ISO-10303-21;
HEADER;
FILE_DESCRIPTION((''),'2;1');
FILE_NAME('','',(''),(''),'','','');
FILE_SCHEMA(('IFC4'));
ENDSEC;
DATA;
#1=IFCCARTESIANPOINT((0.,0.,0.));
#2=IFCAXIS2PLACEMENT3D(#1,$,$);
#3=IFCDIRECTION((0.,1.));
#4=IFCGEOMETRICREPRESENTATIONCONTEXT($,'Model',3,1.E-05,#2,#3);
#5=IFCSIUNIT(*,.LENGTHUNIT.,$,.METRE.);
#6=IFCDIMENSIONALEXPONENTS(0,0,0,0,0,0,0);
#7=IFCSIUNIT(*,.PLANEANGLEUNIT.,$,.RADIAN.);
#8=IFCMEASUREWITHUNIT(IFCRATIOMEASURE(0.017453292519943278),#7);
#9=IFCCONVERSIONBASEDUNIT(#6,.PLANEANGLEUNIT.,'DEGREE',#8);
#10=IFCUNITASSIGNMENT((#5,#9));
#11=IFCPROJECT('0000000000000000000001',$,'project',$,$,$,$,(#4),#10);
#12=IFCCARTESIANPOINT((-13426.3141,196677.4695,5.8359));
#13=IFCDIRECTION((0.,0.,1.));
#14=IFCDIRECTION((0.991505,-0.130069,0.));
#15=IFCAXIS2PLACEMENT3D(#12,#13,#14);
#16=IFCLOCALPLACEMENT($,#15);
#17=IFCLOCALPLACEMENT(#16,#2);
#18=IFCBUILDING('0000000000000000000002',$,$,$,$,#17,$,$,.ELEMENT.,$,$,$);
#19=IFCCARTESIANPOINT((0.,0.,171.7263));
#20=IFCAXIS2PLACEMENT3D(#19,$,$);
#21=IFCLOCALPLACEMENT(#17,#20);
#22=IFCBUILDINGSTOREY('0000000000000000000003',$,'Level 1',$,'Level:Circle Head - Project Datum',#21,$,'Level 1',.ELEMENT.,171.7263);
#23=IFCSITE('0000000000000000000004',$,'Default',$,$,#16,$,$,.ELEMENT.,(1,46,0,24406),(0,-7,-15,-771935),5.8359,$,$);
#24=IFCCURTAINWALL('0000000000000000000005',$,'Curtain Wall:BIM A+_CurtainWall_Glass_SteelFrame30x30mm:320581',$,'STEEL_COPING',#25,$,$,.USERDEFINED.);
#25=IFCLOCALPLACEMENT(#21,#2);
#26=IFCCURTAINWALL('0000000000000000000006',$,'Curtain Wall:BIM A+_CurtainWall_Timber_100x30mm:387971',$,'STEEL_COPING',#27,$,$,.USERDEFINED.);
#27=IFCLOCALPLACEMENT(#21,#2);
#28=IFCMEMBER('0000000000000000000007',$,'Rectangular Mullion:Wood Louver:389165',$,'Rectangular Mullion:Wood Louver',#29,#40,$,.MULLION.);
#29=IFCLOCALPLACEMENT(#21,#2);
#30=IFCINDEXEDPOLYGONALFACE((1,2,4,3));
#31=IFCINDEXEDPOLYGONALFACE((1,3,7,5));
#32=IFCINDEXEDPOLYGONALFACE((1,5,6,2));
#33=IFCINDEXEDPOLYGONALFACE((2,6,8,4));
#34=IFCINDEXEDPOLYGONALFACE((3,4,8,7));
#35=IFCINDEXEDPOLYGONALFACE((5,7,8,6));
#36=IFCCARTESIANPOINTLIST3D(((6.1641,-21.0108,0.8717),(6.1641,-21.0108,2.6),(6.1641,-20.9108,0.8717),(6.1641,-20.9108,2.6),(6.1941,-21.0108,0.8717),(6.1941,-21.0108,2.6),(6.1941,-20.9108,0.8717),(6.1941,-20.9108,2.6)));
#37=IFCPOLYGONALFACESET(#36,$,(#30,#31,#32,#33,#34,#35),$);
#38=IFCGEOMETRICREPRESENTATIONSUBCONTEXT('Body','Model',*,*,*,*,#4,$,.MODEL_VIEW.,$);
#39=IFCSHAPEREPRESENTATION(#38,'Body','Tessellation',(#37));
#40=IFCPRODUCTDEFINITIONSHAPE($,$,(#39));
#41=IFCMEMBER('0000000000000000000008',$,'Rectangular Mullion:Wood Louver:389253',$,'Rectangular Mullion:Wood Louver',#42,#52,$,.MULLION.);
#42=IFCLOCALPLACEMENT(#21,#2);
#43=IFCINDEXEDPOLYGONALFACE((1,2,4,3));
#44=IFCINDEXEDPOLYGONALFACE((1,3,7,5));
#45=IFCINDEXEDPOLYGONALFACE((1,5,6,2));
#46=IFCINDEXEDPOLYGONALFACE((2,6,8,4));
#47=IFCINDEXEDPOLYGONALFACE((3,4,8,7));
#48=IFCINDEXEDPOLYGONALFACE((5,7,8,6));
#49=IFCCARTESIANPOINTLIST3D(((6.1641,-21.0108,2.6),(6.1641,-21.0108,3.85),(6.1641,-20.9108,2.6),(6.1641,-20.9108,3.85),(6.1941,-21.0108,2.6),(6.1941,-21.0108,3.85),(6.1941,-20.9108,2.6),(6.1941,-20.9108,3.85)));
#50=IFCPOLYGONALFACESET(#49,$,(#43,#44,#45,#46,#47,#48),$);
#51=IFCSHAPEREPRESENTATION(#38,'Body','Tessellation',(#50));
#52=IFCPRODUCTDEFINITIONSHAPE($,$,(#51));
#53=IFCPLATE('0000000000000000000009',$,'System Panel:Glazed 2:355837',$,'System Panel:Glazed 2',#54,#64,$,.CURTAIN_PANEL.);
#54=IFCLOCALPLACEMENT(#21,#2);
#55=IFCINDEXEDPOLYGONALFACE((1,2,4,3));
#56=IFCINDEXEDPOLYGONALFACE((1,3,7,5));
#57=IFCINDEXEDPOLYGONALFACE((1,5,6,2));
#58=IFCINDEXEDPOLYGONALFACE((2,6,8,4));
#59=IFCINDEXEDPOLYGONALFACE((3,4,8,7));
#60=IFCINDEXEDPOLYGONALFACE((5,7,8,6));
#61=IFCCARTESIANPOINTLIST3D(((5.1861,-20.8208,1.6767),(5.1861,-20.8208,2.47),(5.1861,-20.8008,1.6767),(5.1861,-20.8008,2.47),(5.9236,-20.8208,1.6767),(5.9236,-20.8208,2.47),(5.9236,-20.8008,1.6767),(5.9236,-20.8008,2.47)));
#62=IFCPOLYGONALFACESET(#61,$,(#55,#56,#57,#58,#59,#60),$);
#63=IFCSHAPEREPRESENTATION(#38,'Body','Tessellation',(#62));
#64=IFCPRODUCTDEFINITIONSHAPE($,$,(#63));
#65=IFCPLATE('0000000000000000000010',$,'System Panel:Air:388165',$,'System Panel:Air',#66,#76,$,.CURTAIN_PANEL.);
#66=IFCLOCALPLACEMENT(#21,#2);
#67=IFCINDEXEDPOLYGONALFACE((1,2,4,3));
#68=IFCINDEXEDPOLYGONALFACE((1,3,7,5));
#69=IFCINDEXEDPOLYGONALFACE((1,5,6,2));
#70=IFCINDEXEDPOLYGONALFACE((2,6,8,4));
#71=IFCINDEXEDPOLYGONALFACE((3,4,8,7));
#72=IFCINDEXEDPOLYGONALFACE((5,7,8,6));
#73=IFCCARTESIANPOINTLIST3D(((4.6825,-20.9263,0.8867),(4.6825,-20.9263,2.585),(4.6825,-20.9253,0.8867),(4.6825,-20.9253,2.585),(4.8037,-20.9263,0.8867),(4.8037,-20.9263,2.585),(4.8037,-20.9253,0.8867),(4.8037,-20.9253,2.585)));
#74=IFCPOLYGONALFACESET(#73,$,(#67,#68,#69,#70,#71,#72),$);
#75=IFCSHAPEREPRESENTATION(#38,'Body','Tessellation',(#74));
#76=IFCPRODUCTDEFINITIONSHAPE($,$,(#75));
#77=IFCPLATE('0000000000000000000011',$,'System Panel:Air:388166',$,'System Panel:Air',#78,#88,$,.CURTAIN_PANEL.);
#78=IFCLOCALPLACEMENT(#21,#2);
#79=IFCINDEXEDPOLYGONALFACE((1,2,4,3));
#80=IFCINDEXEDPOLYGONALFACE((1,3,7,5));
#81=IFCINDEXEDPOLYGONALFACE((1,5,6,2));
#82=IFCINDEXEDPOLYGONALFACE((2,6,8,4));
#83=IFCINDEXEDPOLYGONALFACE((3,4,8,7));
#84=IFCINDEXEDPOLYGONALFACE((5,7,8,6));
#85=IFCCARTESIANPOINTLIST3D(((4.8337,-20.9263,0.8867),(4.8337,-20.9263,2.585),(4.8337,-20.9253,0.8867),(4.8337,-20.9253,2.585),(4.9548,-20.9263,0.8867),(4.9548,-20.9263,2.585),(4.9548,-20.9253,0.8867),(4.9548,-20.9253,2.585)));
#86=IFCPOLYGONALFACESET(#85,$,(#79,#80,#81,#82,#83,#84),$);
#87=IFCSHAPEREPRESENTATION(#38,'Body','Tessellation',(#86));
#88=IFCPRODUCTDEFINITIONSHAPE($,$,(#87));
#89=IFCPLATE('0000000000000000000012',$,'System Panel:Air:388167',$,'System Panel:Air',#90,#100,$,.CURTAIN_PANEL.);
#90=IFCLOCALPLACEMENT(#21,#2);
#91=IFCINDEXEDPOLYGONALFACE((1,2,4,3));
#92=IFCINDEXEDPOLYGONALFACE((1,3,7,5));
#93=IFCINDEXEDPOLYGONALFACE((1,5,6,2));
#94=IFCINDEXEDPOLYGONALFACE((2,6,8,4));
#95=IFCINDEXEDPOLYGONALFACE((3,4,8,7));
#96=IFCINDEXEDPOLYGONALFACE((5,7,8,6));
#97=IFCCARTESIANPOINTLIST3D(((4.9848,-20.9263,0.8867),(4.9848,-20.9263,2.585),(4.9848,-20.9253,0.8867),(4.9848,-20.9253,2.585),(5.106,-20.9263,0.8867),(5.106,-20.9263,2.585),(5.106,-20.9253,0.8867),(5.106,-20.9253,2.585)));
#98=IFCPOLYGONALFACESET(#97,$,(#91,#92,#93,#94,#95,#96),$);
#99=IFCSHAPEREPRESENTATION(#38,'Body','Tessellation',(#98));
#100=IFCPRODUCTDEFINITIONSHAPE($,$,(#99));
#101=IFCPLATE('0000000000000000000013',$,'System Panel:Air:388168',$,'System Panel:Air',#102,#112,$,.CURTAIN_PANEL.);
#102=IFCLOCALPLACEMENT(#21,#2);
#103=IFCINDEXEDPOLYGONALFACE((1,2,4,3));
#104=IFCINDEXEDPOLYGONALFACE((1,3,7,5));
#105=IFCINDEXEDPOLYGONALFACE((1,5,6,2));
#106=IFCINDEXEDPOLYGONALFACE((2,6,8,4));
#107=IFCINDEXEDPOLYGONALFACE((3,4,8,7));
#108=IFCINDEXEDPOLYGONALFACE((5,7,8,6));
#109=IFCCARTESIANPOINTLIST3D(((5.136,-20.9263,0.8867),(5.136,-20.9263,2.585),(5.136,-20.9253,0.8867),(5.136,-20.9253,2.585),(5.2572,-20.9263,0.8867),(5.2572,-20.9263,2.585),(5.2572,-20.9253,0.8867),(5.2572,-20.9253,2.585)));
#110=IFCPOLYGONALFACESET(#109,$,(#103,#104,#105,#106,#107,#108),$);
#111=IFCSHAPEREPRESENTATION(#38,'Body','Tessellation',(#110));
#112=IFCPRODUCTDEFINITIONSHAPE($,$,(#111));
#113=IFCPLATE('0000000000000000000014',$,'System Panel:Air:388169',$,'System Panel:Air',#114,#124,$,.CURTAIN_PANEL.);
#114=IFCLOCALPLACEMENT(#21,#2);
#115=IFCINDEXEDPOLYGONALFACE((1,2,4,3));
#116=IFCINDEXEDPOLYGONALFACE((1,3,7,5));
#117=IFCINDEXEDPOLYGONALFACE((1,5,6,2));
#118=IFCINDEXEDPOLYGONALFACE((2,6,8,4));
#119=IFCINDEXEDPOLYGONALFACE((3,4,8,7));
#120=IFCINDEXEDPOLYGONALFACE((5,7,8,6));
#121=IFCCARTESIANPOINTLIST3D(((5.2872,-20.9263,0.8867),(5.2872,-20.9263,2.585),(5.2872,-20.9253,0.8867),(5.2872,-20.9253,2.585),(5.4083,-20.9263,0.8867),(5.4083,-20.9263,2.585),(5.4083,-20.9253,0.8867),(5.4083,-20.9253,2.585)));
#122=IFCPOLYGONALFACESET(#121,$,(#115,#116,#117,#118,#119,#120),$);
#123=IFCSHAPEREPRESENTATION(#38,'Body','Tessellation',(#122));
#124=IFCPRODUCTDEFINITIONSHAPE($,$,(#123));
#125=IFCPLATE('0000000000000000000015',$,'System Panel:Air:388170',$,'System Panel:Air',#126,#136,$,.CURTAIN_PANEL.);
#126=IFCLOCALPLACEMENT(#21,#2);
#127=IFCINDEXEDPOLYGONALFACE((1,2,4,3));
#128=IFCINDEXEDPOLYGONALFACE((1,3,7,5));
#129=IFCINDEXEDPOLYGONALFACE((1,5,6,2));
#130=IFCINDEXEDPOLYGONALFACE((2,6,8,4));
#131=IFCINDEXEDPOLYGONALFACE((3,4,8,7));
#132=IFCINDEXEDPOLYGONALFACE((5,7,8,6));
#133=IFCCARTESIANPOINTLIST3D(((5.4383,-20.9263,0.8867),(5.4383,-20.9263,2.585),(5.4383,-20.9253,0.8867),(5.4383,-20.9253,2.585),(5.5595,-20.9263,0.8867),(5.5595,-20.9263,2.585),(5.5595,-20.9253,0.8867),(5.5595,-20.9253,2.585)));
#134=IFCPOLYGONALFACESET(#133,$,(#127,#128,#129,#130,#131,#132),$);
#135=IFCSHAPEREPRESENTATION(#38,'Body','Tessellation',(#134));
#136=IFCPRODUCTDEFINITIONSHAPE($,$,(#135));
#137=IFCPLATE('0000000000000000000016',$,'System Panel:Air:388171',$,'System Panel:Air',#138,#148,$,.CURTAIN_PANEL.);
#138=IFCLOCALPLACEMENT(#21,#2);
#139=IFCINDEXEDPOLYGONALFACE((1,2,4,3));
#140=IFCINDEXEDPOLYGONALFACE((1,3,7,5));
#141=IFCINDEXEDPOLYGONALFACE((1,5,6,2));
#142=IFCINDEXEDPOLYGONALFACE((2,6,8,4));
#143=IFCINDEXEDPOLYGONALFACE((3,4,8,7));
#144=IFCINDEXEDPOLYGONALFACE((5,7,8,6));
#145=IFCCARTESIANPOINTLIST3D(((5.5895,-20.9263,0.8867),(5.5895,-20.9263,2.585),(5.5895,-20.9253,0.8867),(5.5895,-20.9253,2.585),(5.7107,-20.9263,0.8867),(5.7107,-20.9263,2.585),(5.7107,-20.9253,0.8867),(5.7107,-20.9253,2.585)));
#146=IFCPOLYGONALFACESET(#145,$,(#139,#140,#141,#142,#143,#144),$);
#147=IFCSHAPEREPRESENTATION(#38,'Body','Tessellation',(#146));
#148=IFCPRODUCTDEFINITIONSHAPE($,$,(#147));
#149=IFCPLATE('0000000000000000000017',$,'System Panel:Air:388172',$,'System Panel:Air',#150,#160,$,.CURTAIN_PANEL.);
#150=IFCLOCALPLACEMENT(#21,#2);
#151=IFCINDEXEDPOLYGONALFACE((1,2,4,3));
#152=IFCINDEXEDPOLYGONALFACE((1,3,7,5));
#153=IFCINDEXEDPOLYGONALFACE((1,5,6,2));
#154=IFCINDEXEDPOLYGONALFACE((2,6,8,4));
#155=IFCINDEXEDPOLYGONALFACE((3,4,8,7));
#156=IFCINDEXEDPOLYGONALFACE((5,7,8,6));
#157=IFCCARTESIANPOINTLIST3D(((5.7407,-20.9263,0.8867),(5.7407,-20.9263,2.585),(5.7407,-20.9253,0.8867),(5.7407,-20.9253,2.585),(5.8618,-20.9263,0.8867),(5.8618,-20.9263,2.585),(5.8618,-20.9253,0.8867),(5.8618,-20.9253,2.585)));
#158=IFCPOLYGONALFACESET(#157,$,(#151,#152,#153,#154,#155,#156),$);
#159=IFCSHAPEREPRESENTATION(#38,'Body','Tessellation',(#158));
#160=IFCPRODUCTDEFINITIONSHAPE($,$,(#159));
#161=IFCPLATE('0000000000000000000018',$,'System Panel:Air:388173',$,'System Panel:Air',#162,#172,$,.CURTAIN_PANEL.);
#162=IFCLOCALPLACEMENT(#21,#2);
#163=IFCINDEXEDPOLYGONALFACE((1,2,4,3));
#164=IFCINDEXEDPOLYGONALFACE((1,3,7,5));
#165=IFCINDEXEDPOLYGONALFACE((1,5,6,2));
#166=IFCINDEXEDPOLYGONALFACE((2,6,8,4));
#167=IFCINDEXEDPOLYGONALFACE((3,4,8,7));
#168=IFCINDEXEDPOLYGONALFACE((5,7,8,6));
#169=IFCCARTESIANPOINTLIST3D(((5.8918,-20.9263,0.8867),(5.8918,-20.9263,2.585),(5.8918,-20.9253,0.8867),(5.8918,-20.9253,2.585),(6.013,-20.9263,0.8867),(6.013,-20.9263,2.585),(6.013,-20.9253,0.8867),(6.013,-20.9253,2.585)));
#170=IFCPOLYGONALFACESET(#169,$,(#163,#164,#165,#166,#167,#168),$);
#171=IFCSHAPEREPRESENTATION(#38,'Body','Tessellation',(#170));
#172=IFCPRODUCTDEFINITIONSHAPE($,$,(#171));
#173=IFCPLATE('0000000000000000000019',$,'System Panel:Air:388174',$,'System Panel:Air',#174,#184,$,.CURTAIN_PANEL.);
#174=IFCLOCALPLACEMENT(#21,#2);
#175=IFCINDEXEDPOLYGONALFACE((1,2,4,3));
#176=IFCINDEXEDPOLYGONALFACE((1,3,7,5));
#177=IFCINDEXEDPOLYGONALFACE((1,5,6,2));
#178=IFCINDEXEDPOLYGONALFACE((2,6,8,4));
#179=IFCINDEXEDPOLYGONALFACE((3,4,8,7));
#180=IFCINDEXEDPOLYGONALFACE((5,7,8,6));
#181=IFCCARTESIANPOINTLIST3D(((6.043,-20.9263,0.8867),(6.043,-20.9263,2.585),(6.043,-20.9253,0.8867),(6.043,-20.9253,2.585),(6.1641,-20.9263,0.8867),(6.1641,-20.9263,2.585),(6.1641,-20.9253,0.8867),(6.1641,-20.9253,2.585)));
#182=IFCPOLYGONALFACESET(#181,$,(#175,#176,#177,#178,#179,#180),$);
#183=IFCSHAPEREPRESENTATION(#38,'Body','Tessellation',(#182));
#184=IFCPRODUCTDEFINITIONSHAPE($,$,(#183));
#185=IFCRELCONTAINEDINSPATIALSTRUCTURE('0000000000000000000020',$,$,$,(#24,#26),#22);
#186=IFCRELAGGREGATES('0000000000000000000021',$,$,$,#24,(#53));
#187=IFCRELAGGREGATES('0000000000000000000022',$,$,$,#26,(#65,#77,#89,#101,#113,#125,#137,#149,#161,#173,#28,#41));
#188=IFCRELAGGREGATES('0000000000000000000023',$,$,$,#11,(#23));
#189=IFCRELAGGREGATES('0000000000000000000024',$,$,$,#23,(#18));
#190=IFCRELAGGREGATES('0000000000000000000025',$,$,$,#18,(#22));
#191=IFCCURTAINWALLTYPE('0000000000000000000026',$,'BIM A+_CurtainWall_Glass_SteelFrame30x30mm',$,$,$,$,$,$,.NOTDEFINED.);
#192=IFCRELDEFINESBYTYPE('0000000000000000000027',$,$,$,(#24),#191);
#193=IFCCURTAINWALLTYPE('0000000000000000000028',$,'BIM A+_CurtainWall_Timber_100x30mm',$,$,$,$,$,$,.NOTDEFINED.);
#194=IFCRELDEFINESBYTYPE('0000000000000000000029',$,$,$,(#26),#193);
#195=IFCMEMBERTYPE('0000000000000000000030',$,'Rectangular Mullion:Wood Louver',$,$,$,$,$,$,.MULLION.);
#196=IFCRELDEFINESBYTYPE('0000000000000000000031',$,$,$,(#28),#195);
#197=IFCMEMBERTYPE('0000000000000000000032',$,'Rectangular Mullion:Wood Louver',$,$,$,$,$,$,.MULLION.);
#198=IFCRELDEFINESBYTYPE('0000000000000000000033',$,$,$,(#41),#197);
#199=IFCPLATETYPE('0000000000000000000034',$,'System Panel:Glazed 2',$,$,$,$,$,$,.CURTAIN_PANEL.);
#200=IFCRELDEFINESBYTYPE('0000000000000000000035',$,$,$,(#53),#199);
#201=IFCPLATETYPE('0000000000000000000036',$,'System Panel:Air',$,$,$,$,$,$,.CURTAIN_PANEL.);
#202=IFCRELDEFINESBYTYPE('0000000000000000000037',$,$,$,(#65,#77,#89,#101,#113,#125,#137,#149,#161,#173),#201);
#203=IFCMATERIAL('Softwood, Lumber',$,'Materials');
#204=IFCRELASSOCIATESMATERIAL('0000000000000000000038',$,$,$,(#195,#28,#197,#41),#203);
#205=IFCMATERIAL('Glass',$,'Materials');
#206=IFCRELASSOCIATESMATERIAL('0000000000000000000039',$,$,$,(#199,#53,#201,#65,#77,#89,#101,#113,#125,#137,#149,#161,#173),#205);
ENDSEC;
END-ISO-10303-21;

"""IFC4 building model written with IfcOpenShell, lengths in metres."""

from ifc_helpers import new_model, entity, si_unit, converted_unit, direction, frame, origin, place, context, subcontext, project, spatial, indexed_curve, outline, extrude, source, transform, mapped, material, type_object, type_shapes, element, aggregate, save


model = new_model("IFC4")

# Units and contexts
model_context = context("Model", 3, precision=1e-05, world=origin(), true_north=direction((0.0, 1.0)))
body_context = subcontext(model_context, "Body", "Model", "MODEL_VIEW")
ifc_project = project(units=[si_unit("LENGTHUNIT", "METRE"), converted_unit("PLANEANGLEUNIT", "DEGREE", entity("IfcRatioMeasure", 0.017453292519943278), si_unit("PLANEANGLEUNIT", "RADIAN"), dimensions=[0, 0, 0, 0, 0, 0, 0])], contexts=[model_context])

# Site, building, storey
site_placement = place(None, frame((-13426.3141, 196677.4695, 5.8359), z_axis=(0.0, 0.0, 1.0), x_axis=(0.991505, -0.130069, 0.0)))
site = spatial("IfcSite", under=ifc_project, at=site_placement, Name="Default", CompositionType="ELEMENT", RefLatitude=(1, 46, 0, 24406), RefLongitude=(0, -7, -15, -771935), RefElevation=5.8359)
building_placement = place(site_placement, origin())
building = spatial("IfcBuilding", under=site, at=building_placement, CompositionType="ELEMENT")
storey_placement = place(building_placement, frame((0.0, 0.0, 171.7263)))
storey = spatial("IfcBuildingStorey", under=building, at=storey_placement, Name="Level 1", ObjectType="Level:Circle Head - Project Datum", LongName="Level 1", CompositionType="ELEMENT", Elevation=171.7263)

# Curtain wall
curtain_wall_type_1 = type_object("IfcCurtainWallType", Name="BIM A+_CurtainWall_Glass_SteelFrame30x30mm", PredefinedType="NOTDEFINED")
curtain_wall_1_placement = place(storey_placement, frame((0.0, 0.0, -171.7263)))
curtain_wall_1 = element("IfcCurtainWall", 1, at=curtain_wall_1_placement, inside=storey, type_object=curtain_wall_type_1, Name="Curtain Wall:BIM A+_CurtainWall_Glass_SteelFrame30x30mm:320581", ObjectType="STEEL_COPING", PredefinedType="USERDEFINED")

# Curtain wall, members
curtain_wall_type_2 = type_object("IfcCurtainWallType", Name="BIM A+_CurtainWall_Timber_100x30mm", PredefinedType="NOTDEFINED")
curtain_wall_2_placement = place(storey_placement, frame((0.0, 0.0, -171.7263)))
curtain_wall_2 = element("IfcCurtainWall", 2, at=curtain_wall_2_placement, inside=storey, type_object=curtain_wall_type_2, Name="Curtain Wall:BIM A+_CurtainWall_Timber_100x30mm:387971", ObjectType="STEEL_COPING", PredefinedType="USERDEFINED")
ifc_material_1 = material(Name="Softwood, Lumber", Category="Materials")
member_type_1 = type_object("IfcMemberType", Name="Rectangular Mullion:Wood Louver", PredefinedType="MULLION", material=ifc_material_1)
shared_shape_1 = source(origin(), body_context, "Body", "SweptSolid", [
    extrude(outline(indexed_curve([(-0.05, -0.015), (0.05, -0.015), (0.05, 0.015), (-0.05, 0.015), (-0.05, -0.015)], self_intersect=False)), frame((0.0, 0.035, -1.7283), z_axis=(0.0, 0.0, 1.0), x_axis=(0.0, -1.0, 0.0)), (0.0, 0.0, 1.0), 1.7283),
])
type_shapes(member_type_1, [shared_shape_1])
member_1_placement = place(curtain_wall_2_placement, frame((6.1791, -20.9258, 172.598), z_axis=(0.0, 0.0, -1.0), x_axis=(1.0, 0.0, 0.0)))
member_1 = element("IfcMember", 3, at=member_1_placement, type_object=member_type_1, material=ifc_material_1, Name="Rectangular Mullion:Wood Louver:389165", ObjectType="Rectangular Mullion:Wood Louver", PredefinedType="MULLION", context=body_context, shape_type="MappedRepresentation", body=[
    mapped(shared_shape_1, transform((0.0, 0.0, 0.0), scale=1.0)),
])
member_type_2 = type_object("IfcMemberType", Name="Rectangular Mullion:Wood Louver", PredefinedType="MULLION", material=ifc_material_1)
shared_shape_2 = source(origin(), body_context, "Body", "SweptSolid", [
    extrude(outline(indexed_curve([(-0.05, -0.015), (0.05, -0.015), (0.05, 0.015), (-0.05, 0.015), (-0.05, -0.015)], self_intersect=False)), frame((0.0, 0.035, -1.25), z_axis=(0.0, 0.0, 1.0), x_axis=(0.0, -1.0, 0.0)), (0.0, 0.0, 1.0), 1.25),
])
type_shapes(member_type_2, [shared_shape_2])
member_2_placement = place(curtain_wall_2_placement, frame((6.1791, -20.9258, 174.3263), z_axis=(0.0, 0.0, -1.0), x_axis=(1.0, 0.0, 0.0)))
member_2 = element("IfcMember", 4, at=member_2_placement, type_object=member_type_2, material=ifc_material_1, Name="Rectangular Mullion:Wood Louver:389253", ObjectType="Rectangular Mullion:Wood Louver", PredefinedType="MULLION", context=body_context, shape_type="MappedRepresentation", body=[
    mapped(shared_shape_2, transform((0.0, 0.0, 0.0), scale=1.0)),
])

# Plates
ifc_material_2 = material(Name="Glass", Category="Materials")
plate_type_1 = type_object("IfcPlateType", Name="System Panel:Glazed 2", PredefinedType="CURTAIN_PANEL", material=ifc_material_2)
shared_shape_3 = source(origin(), body_context, "Body", "SweptSolid", [
    extrude(outline(indexed_curve([(-0.01, -0.3688), (0.01, -0.3688), (0.01, 0.3688), (-0.01, 0.3688), (-0.01, -0.3688)], self_intersect=False)), frame((0.0, 0.0, 0.0), z_axis=(0.0, 0.0, 1.0), x_axis=(0.0, 1.0, 0.0)), (0.0, 0.0, 1.0), 0.7933),
])
type_shapes(plate_type_1, [shared_shape_3])
plate_1_placement = place(curtain_wall_1_placement, frame((5.5548, -20.8108, 173.4029)))
plate_1 = element("IfcPlate", 5, at=plate_1_placement, type_object=plate_type_1, material=ifc_material_2, Name="System Panel:Glazed 2:355837", ObjectType="System Panel:Glazed 2", PredefinedType="CURTAIN_PANEL", context=body_context, shape_type="MappedRepresentation", body=[
    mapped(shared_shape_3, transform((0.0, 0.0, 0.0), scale=1.0)),
])
aggregate(curtain_wall_1, [plate_1])
plate_type_2 = type_object("IfcPlateType", Name="System Panel:Air", PredefinedType="CURTAIN_PANEL", material=ifc_material_2)
shared_shape_4 = source(origin(), body_context, "Body", "SweptSolid", [
    extrude(outline(indexed_curve([(-0.0005, -0.0606), (0.0005, -0.0606), (0.0005, 0.0606), (-0.0005, 0.0606), (-0.0005, -0.0606)], self_intersect=False)), frame((0.0, 0.0, 0.0), z_axis=(0.0, 0.0, 1.0), x_axis=(0.0, 1.0, 0.0)), (0.0, 0.0, 1.0), 1.6983),
])
type_shapes(plate_type_2, [shared_shape_4])
plate_2_placement = place(curtain_wall_2_placement, frame((4.7431, -20.9258, 172.613)))
plate_2 = element("IfcPlate", 6, at=plate_2_placement, type_object=plate_type_2, material=ifc_material_2, Name="System Panel:Air:388165", ObjectType="System Panel:Air", PredefinedType="CURTAIN_PANEL", context=body_context, shape_type="MappedRepresentation", body=[
    mapped(shared_shape_4, transform((0.0, 0.0, 0.0), scale=1.0)),
])
plate_3_placement = place(curtain_wall_2_placement, frame((4.8943, -20.9258, 172.613)))
plate_3 = element("IfcPlate", 7, at=plate_3_placement, type_object=plate_type_2, material=ifc_material_2, Name="System Panel:Air:388166", ObjectType="System Panel:Air", PredefinedType="CURTAIN_PANEL", context=body_context, shape_type="MappedRepresentation", body=[
    mapped(shared_shape_4, transform((0.0, 0.0, 0.0), scale=1.0)),
])
plate_4_placement = place(curtain_wall_2_placement, frame((5.0454, -20.9258, 172.613)))
plate_4 = element("IfcPlate", 8, at=plate_4_placement, type_object=plate_type_2, material=ifc_material_2, Name="System Panel:Air:388167", ObjectType="System Panel:Air", PredefinedType="CURTAIN_PANEL", context=body_context, shape_type="MappedRepresentation", body=[
    mapped(shared_shape_4, transform((0.0, 0.0, 0.0), scale=1.0)),
])
plate_5_placement = place(curtain_wall_2_placement, frame((5.1966, -20.9258, 172.613)))
plate_5 = element("IfcPlate", 9, at=plate_5_placement, type_object=plate_type_2, material=ifc_material_2, Name="System Panel:Air:388168", ObjectType="System Panel:Air", PredefinedType="CURTAIN_PANEL", context=body_context, shape_type="MappedRepresentation", body=[
    mapped(shared_shape_4, transform((0.0, 0.0, 0.0), scale=1.0)),
])
plate_6_placement = place(curtain_wall_2_placement, frame((5.3477, -20.9258, 172.613)))
plate_6 = element("IfcPlate", 10, at=plate_6_placement, type_object=plate_type_2, material=ifc_material_2, Name="System Panel:Air:388169", ObjectType="System Panel:Air", PredefinedType="CURTAIN_PANEL", context=body_context, shape_type="MappedRepresentation", body=[
    mapped(shared_shape_4, transform((0.0, 0.0, 0.0), scale=1.0)),
])
plate_7_placement = place(curtain_wall_2_placement, frame((5.4989, -20.9258, 172.613)))
plate_7 = element("IfcPlate", 11, at=plate_7_placement, type_object=plate_type_2, material=ifc_material_2, Name="System Panel:Air:388170", ObjectType="System Panel:Air", PredefinedType="CURTAIN_PANEL", context=body_context, shape_type="MappedRepresentation", body=[
    mapped(shared_shape_4, transform((0.0, 0.0, 0.0), scale=1.0)),
])
plate_8_placement = place(curtain_wall_2_placement, frame((5.6501, -20.9258, 172.613)))
plate_8 = element("IfcPlate", 12, at=plate_8_placement, type_object=plate_type_2, material=ifc_material_2, Name="System Panel:Air:388171", ObjectType="System Panel:Air", PredefinedType="CURTAIN_PANEL", context=body_context, shape_type="MappedRepresentation", body=[
    mapped(shared_shape_4, transform((0.0, 0.0, 0.0), scale=1.0)),
])
plate_9_placement = place(curtain_wall_2_placement, frame((5.8012, -20.9258, 172.613)))
plate_9 = element("IfcPlate", 13, at=plate_9_placement, type_object=plate_type_2, material=ifc_material_2, Name="System Panel:Air:388172", ObjectType="System Panel:Air", PredefinedType="CURTAIN_PANEL", context=body_context, shape_type="MappedRepresentation", body=[
    mapped(shared_shape_4, transform((0.0, 0.0, 0.0), scale=1.0)),
])
plate_10_placement = place(curtain_wall_2_placement, frame((5.9524, -20.9258, 172.613)))
plate_10 = element("IfcPlate", 14, at=plate_10_placement, type_object=plate_type_2, material=ifc_material_2, Name="System Panel:Air:388173", ObjectType="System Panel:Air", PredefinedType="CURTAIN_PANEL", context=body_context, shape_type="MappedRepresentation", body=[
    mapped(shared_shape_4, transform((0.0, 0.0, 0.0), scale=1.0)),
])
plate_11_placement = place(curtain_wall_2_placement, frame((6.1036, -20.9258, 172.613)))
plate_11 = element("IfcPlate", 15, at=plate_11_placement, type_object=plate_type_2, material=ifc_material_2, Name="System Panel:Air:388174", ObjectType="System Panel:Air", PredefinedType="CURTAIN_PANEL", context=body_context, shape_type="MappedRepresentation", body=[
    mapped(shared_shape_4, transform((0.0, 0.0, 0.0), scale=1.0)),
])
aggregate(curtain_wall_2, [plate_2, plate_3, plate_4, plate_5, plate_6, plate_7, plate_8, plate_9, plate_10, plate_11, member_1, member_2])

save(model, "model.ifc")
